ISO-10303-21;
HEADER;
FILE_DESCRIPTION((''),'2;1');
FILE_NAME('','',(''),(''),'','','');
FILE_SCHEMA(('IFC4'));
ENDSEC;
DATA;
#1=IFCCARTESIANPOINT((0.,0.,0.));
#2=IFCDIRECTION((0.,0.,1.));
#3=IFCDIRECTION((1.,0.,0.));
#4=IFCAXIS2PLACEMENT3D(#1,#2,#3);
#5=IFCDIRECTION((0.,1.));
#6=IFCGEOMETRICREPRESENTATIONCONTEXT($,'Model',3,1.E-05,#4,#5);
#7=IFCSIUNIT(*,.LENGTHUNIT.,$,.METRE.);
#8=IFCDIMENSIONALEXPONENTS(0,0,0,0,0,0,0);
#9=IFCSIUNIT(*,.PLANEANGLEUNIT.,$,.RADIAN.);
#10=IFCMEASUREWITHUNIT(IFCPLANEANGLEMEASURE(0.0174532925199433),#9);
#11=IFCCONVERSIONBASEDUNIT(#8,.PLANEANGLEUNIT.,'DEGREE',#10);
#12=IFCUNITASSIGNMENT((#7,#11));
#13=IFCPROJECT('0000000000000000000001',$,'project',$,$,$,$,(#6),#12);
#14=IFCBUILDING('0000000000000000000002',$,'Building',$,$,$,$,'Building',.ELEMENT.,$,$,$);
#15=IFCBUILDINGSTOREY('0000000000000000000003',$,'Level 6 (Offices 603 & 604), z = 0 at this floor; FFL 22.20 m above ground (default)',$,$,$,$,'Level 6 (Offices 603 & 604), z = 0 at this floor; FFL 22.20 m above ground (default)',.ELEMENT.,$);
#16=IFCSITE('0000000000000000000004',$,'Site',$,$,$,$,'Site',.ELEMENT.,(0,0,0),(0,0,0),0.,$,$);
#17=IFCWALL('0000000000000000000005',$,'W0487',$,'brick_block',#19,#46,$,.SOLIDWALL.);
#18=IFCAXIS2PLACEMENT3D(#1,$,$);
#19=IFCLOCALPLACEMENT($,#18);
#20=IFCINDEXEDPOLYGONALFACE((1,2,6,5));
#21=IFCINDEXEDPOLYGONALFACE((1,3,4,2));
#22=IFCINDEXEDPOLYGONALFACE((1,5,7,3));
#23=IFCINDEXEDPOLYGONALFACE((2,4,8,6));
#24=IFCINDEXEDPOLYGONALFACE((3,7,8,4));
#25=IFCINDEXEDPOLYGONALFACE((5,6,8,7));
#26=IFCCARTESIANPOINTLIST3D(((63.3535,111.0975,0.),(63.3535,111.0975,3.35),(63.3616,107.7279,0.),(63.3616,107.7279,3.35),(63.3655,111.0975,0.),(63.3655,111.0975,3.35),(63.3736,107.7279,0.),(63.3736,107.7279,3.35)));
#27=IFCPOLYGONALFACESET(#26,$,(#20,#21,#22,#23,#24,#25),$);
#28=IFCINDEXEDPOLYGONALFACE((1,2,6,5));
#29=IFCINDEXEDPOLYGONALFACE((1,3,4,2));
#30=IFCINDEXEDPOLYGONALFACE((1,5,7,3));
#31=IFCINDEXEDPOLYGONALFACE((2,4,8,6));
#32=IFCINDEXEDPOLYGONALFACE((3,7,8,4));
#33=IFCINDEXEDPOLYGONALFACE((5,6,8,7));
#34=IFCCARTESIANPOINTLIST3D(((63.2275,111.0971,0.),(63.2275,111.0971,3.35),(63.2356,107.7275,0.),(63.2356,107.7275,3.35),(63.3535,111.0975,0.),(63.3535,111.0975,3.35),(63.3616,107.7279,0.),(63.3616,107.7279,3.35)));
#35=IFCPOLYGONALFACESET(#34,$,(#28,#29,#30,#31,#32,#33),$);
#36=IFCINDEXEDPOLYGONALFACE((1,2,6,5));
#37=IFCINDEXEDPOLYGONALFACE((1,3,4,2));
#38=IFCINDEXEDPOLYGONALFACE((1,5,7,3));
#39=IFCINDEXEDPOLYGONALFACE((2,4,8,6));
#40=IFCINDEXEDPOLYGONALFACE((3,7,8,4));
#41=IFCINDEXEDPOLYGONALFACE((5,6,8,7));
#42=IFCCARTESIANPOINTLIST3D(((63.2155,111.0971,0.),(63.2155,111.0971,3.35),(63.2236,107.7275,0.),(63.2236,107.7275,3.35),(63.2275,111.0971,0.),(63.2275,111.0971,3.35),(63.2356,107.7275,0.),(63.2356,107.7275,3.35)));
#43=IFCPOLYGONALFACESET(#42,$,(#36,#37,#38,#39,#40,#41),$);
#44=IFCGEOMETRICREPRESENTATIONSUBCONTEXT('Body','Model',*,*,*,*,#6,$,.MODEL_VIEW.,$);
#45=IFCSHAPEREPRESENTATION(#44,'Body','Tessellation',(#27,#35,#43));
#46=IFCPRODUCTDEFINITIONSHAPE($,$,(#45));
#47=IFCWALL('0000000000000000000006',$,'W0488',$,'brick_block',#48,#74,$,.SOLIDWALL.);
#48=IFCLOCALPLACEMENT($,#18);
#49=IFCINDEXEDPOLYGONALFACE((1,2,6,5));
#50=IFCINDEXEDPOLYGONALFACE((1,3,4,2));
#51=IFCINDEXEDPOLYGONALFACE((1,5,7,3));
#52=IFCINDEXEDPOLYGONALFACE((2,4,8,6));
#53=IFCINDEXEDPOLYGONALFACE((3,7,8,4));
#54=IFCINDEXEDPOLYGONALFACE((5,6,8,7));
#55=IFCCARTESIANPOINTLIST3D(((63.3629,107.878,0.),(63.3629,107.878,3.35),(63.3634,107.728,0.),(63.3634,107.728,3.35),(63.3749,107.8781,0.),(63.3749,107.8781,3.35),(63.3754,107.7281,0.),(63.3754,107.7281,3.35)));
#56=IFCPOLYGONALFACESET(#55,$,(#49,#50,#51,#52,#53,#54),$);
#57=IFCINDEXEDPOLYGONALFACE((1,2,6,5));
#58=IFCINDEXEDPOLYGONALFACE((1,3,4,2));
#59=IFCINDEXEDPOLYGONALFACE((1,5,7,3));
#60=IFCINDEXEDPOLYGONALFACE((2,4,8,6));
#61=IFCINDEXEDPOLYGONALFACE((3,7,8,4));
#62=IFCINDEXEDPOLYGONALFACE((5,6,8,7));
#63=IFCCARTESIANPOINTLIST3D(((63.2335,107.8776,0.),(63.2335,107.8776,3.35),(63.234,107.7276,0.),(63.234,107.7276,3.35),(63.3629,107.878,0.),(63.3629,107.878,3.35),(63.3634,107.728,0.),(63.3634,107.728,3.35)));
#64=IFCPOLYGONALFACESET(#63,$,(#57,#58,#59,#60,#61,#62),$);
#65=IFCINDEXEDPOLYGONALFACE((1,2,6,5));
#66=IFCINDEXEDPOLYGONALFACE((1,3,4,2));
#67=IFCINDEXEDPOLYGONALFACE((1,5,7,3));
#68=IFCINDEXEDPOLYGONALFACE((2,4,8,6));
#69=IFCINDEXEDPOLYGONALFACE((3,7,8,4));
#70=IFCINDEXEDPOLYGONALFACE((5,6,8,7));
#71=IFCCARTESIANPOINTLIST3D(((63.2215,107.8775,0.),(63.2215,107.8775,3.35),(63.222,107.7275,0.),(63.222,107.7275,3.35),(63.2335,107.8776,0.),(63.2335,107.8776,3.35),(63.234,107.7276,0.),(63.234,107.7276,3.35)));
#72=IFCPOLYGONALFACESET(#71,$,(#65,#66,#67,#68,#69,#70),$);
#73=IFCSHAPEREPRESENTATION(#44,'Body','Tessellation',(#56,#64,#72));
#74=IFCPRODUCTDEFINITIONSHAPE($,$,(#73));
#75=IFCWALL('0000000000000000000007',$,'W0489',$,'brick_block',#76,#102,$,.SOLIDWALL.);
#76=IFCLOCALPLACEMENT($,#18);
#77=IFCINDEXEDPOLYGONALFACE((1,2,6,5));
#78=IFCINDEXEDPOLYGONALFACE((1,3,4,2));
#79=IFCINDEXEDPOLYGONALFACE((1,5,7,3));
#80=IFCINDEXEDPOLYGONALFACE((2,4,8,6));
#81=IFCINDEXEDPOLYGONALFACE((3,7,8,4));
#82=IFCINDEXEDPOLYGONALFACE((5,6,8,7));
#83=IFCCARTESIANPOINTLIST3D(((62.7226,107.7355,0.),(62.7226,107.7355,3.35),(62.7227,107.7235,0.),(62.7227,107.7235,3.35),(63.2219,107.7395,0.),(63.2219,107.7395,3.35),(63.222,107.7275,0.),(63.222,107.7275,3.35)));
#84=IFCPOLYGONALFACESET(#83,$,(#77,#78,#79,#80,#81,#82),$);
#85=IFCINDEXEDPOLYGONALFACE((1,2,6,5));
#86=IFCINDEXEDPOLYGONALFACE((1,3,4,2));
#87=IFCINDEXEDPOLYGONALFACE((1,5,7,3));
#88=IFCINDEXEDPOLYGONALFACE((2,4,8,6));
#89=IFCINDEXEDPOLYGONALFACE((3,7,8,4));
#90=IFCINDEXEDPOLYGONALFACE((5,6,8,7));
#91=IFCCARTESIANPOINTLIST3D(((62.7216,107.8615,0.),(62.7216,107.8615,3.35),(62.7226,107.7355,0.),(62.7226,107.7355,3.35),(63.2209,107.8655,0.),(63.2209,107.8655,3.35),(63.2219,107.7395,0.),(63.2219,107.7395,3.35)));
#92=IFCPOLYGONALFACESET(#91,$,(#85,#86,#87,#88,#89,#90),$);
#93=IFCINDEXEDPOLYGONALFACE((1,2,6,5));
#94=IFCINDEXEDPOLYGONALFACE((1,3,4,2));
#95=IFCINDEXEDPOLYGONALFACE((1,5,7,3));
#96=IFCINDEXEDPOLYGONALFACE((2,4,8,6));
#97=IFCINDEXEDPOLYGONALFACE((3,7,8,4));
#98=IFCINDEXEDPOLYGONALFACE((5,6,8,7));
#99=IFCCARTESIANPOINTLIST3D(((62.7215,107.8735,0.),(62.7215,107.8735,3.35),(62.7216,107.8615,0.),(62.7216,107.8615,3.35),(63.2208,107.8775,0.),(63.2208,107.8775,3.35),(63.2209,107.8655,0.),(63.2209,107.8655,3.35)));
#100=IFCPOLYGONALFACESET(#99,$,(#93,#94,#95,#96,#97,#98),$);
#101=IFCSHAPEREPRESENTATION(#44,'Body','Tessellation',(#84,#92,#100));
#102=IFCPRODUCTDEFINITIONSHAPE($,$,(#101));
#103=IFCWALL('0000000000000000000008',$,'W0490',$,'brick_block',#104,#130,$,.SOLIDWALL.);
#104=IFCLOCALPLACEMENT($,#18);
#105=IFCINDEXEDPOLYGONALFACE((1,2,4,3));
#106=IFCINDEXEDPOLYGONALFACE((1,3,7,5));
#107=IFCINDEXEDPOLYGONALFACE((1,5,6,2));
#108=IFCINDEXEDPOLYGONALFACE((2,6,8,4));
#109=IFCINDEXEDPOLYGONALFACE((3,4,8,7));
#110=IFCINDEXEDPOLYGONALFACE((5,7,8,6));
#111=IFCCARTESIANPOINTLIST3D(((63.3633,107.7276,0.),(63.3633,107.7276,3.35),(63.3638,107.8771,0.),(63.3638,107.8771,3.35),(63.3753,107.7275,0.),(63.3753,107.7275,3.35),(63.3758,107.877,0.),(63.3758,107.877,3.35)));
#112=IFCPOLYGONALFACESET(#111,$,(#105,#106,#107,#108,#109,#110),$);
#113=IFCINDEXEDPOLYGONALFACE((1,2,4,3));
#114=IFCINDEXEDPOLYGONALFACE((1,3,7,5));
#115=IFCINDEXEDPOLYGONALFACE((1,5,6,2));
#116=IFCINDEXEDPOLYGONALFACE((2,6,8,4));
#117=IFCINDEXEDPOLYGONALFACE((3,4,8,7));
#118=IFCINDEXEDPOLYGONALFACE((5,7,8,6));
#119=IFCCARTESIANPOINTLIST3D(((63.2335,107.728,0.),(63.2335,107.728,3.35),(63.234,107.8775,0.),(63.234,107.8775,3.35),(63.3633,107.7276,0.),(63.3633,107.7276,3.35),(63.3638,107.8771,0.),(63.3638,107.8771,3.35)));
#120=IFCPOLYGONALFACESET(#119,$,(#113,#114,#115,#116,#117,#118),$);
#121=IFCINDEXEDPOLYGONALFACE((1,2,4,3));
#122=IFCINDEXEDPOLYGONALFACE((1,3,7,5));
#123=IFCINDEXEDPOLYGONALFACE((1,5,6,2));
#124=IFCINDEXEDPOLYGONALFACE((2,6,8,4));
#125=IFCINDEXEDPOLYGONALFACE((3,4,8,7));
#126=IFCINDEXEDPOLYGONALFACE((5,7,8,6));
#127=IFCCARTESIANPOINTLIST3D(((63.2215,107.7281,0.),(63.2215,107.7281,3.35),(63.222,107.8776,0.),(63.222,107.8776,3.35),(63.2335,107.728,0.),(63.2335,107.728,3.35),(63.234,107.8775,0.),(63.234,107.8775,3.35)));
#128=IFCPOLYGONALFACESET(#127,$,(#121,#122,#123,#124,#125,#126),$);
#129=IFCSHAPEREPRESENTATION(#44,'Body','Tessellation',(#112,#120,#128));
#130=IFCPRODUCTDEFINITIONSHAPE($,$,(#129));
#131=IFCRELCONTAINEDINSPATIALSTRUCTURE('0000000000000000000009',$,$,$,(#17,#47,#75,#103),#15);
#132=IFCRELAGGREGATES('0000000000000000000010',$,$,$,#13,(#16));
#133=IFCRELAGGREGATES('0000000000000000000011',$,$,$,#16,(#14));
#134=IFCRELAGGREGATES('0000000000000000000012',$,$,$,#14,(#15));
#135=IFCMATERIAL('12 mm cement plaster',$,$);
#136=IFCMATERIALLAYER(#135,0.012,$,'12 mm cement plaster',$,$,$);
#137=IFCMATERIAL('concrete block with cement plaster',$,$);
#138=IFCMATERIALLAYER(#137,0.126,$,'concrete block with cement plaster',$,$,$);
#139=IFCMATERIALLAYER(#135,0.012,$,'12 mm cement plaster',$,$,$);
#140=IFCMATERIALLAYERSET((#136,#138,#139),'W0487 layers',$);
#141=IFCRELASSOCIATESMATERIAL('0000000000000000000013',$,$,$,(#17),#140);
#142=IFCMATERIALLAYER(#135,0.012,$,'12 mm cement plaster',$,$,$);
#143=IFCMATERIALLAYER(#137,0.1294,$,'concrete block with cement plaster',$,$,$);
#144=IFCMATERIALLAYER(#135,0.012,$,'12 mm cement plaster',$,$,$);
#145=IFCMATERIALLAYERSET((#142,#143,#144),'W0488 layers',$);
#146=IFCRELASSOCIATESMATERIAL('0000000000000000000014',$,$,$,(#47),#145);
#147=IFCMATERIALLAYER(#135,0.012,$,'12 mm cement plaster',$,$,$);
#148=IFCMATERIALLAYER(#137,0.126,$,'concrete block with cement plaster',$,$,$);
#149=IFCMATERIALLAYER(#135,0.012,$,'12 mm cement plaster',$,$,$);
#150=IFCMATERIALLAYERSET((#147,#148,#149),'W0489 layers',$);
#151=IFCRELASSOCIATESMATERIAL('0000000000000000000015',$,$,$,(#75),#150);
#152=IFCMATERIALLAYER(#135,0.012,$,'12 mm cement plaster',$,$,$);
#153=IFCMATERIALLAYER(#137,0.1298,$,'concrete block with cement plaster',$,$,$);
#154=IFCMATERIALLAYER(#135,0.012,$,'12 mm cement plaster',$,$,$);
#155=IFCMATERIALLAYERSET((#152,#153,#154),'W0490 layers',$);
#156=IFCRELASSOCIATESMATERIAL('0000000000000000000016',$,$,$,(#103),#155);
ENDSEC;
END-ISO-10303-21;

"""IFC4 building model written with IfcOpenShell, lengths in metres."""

from ifc_helpers import new_model, entity, si_unit, converted_unit, direction, frame, frame_2d, origin_with_axes, place, context, subcontext, project, spatial, rectangle, extrude, material, layer, layer_set, layer_usage, element, save


model = new_model("IFC4")

# Units and contexts
model_context = context("Model", 3, precision=1e-05, world=origin_with_axes(), true_north=direction((0.0, 1.0)))
body_context = subcontext(model_context, "Body", "Model", "MODEL_VIEW")
ifc_project = project(units=[si_unit("LENGTHUNIT", "METRE"), converted_unit("PLANEANGLEUNIT", "DEGREE", entity("IfcPlaneAngleMeasure", 0.0174532925199433), si_unit("PLANEANGLEUNIT", "RADIAN"), dimensions=[0, 0, 0, 0, 0, 0, 0])], contexts=[model_context])

# Site, building, storey
site = spatial("IfcSite", under=ifc_project, Name="Site", LongName="Site", CompositionType="ELEMENT", RefLatitude=(0, 0, 0), RefLongitude=(0, 0, 0), RefElevation=0.0)
building = spatial("IfcBuilding", under=site, Name="Building", LongName="Building", CompositionType="ELEMENT")
storey = spatial("IfcBuildingStorey", under=building, Name="Level 6 (Offices 603 & 604), z = 0 at this floor; FFL 22.20 m above ground (default)", LongName="Level 6 (Offices 603 & 604), z = 0 at this floor; FFL 22.20 m above ground (default)", CompositionType="ELEMENT")

# Walls
placement = place(None, origin_with_axes())
ifc_material_1 = material(Name="12 mm cement plaster")
ifc_material_2 = material(Name="concrete block with cement plaster")
ifc_layer_1 = layer(ifc_material_1, 0.012, Name="12 mm cement plaster")
ifc_layer_2 = layer(ifc_material_2, 0.126, Name="concrete block with cement plaster")
ifc_layer_3 = layer(ifc_material_1, 0.012, Name="12 mm cement plaster")
ifc_layer_set_1 = layer_set([ifc_layer_1, ifc_layer_2, ifc_layer_3], Name="W0487 layers")
ifc_layer_usage_1 = layer_usage(ifc_layer_set_1, "AXIS2", "POSITIVE", -0.075)
element("IfcWall", 1, at=placement, inside=storey, material=ifc_layer_usage_1, Name="W0487", ObjectType="brick_block", PredefinedType="SOLIDWALL", context=body_context, shape_type="SweptSolid", body=[
    extrude(rectangle(XDim=3.3696, YDim=0.012, at=frame_2d((0.0, 0.0), x_axis=(0.002404, -0.999997))), frame((63.3635, 109.4127, 0.0), z_axis=(0.0, 0.0, 1.0), x_axis=(1.0, 0.0, 0.0)), (0.0, 0.0, 1.0), 3.35),
    extrude(rectangle(XDim=3.3696, YDim=0.126, at=frame_2d((-0.069, -0.0002), x_axis=(0.002404, -0.999997))), frame((63.3635, 109.4127, 0.0), z_axis=(0.0, 0.0, 1.0), x_axis=(1.0, 0.0, 0.0)), (0.0, 0.0, 1.0), 3.35),
    extrude(rectangle(XDim=3.3696, YDim=0.012, at=frame_2d((-0.138, -0.0003), x_axis=(0.002404, -0.999997))), frame((63.3635, 109.4127, 0.0), z_axis=(0.0, 0.0, 1.0), x_axis=(1.0, 0.0, 0.0)), (0.0, 0.0, 1.0), 3.35),
])
ifc_layer_4 = layer(ifc_material_1, 0.012, Name="12 mm cement plaster")
ifc_layer_5 = layer(ifc_material_2, 0.1294, Name="concrete block with cement plaster")
ifc_layer_6 = layer(ifc_material_1, 0.012, Name="12 mm cement plaster")
ifc_layer_set_2 = layer_set([ifc_layer_4, ifc_layer_5, ifc_layer_6], Name="W0488 layers")
ifc_layer_usage_2 = layer_usage(ifc_layer_set_2, "AXIS2", "POSITIVE", -0.0767)
element("IfcWall", 2, at=placement, inside=storey, material=ifc_layer_usage_2, Name="W0488", ObjectType="brick_block", PredefinedType="SOLIDWALL", context=body_context, shape_type="SweptSolid", body=[
    extrude(rectangle(XDim=0.15, YDim=0.012, at=frame_2d((0.0, 0.0), x_axis=(0.003333, -0.999994))), frame((63.3691, 107.803, 0.0), z_axis=(0.0, 0.0, 1.0), x_axis=(1.0, 0.0, 0.0)), (0.0, 0.0, 1.0), 3.35),
    extrude(rectangle(XDim=0.15, YDim=0.1294, at=frame_2d((-0.0707, -0.0002), x_axis=(0.003333, -0.999994))), frame((63.3691, 107.803, 0.0), z_axis=(0.0, 0.0, 1.0), x_axis=(1.0, 0.0, 0.0)), (0.0, 0.0, 1.0), 3.35),
    extrude(rectangle(XDim=0.15, YDim=0.012, at=frame_2d((-0.1414, -0.0005), x_axis=(0.003333, -0.999994))), frame((63.3691, 107.803, 0.0), z_axis=(0.0, 0.0, 1.0), x_axis=(1.0, 0.0, 0.0)), (0.0, 0.0, 1.0), 3.35),
])
ifc_layer_7 = layer(ifc_material_1, 0.012, Name="12 mm cement plaster")
ifc_layer_8 = layer(ifc_material_2, 0.126, Name="concrete block with cement plaster")
ifc_layer_9 = layer(ifc_material_1, 0.012, Name="12 mm cement plaster")
ifc_layer_set_3 = layer_set([ifc_layer_7, ifc_layer_8, ifc_layer_9], Name="W0489 layers")
ifc_layer_usage_3 = layer_usage(ifc_layer_set_3, "AXIS2", "POSITIVE", -0.075)
element("IfcWall", 3, at=placement, inside=storey, material=ifc_layer_usage_3, Name="W0489", ObjectType="brick_block", PredefinedType="SOLIDWALL", context=body_context, shape_type="SweptSolid", body=[
    extrude(rectangle(XDim=0.4993, YDim=0.012, at=frame_2d((0.0, 0.0), x_axis=(0.999968, 0.008011))), frame((62.9723, 107.7315, 0.0), z_axis=(0.0, 0.0, 1.0), x_axis=(1.0, 0.0, 0.0)), (0.0, 0.0, 1.0), 3.35),
    extrude(rectangle(XDim=0.4993, YDim=0.126, at=frame_2d((-0.0006, 0.069), x_axis=(0.999968, 0.008011))), frame((62.9723, 107.7315, 0.0), z_axis=(0.0, 0.0, 1.0), x_axis=(1.0, 0.0, 0.0)), (0.0, 0.0, 1.0), 3.35),
    extrude(rectangle(XDim=0.4993, YDim=0.012, at=frame_2d((-0.0011, 0.138), x_axis=(0.999968, 0.008011))), frame((62.9723, 107.7315, 0.0), z_axis=(0.0, 0.0, 1.0), x_axis=(1.0, 0.0, 0.0)), (0.0, 0.0, 1.0), 3.35),
])
ifc_layer_10 = layer(ifc_material_1, 0.012, Name="12 mm cement plaster")
ifc_layer_11 = layer(ifc_material_2, 0.1298, Name="concrete block with cement plaster")
ifc_layer_12 = layer(ifc_material_1, 0.012, Name="12 mm cement plaster")
ifc_layer_set_4 = layer_set([ifc_layer_10, ifc_layer_11, ifc_layer_12], Name="W0490 layers")
ifc_layer_usage_4 = layer_usage(ifc_layer_set_4, "AXIS2", "POSITIVE", -0.0769)
element("IfcWall", 4, at=placement, inside=storey, material=ifc_layer_usage_4, Name="W0490", ObjectType="brick_block", PredefinedType="SOLIDWALL", context=body_context, shape_type="SweptSolid", body=[
    extrude(rectangle(XDim=0.1495, YDim=0.012, at=frame_2d((0.0, 0.0), x_axis=(0.003344, 0.999994))), frame((63.3695, 107.8023, 0.0), z_axis=(0.0, 0.0, 1.0), x_axis=(1.0, 0.0, 0.0)), (0.0, 0.0, 1.0), 3.35),
    extrude(rectangle(XDim=0.1495, YDim=0.1298, at=frame_2d((-0.0709, 0.0002), x_axis=(0.003344, 0.999994))), frame((63.3695, 107.8023, 0.0), z_axis=(0.0, 0.0, 1.0), x_axis=(1.0, 0.0, 0.0)), (0.0, 0.0, 1.0), 3.35),
    extrude(rectangle(XDim=0.1495, YDim=0.012, at=frame_2d((-0.1418, 0.0005), x_axis=(0.003344, 0.999994))), frame((63.3695, 107.8023, 0.0), z_axis=(0.0, 0.0, 1.0), x_axis=(1.0, 0.0, 0.0)), (0.0, 0.0, 1.0), 3.35),
])

save(model, "model.ifc")
